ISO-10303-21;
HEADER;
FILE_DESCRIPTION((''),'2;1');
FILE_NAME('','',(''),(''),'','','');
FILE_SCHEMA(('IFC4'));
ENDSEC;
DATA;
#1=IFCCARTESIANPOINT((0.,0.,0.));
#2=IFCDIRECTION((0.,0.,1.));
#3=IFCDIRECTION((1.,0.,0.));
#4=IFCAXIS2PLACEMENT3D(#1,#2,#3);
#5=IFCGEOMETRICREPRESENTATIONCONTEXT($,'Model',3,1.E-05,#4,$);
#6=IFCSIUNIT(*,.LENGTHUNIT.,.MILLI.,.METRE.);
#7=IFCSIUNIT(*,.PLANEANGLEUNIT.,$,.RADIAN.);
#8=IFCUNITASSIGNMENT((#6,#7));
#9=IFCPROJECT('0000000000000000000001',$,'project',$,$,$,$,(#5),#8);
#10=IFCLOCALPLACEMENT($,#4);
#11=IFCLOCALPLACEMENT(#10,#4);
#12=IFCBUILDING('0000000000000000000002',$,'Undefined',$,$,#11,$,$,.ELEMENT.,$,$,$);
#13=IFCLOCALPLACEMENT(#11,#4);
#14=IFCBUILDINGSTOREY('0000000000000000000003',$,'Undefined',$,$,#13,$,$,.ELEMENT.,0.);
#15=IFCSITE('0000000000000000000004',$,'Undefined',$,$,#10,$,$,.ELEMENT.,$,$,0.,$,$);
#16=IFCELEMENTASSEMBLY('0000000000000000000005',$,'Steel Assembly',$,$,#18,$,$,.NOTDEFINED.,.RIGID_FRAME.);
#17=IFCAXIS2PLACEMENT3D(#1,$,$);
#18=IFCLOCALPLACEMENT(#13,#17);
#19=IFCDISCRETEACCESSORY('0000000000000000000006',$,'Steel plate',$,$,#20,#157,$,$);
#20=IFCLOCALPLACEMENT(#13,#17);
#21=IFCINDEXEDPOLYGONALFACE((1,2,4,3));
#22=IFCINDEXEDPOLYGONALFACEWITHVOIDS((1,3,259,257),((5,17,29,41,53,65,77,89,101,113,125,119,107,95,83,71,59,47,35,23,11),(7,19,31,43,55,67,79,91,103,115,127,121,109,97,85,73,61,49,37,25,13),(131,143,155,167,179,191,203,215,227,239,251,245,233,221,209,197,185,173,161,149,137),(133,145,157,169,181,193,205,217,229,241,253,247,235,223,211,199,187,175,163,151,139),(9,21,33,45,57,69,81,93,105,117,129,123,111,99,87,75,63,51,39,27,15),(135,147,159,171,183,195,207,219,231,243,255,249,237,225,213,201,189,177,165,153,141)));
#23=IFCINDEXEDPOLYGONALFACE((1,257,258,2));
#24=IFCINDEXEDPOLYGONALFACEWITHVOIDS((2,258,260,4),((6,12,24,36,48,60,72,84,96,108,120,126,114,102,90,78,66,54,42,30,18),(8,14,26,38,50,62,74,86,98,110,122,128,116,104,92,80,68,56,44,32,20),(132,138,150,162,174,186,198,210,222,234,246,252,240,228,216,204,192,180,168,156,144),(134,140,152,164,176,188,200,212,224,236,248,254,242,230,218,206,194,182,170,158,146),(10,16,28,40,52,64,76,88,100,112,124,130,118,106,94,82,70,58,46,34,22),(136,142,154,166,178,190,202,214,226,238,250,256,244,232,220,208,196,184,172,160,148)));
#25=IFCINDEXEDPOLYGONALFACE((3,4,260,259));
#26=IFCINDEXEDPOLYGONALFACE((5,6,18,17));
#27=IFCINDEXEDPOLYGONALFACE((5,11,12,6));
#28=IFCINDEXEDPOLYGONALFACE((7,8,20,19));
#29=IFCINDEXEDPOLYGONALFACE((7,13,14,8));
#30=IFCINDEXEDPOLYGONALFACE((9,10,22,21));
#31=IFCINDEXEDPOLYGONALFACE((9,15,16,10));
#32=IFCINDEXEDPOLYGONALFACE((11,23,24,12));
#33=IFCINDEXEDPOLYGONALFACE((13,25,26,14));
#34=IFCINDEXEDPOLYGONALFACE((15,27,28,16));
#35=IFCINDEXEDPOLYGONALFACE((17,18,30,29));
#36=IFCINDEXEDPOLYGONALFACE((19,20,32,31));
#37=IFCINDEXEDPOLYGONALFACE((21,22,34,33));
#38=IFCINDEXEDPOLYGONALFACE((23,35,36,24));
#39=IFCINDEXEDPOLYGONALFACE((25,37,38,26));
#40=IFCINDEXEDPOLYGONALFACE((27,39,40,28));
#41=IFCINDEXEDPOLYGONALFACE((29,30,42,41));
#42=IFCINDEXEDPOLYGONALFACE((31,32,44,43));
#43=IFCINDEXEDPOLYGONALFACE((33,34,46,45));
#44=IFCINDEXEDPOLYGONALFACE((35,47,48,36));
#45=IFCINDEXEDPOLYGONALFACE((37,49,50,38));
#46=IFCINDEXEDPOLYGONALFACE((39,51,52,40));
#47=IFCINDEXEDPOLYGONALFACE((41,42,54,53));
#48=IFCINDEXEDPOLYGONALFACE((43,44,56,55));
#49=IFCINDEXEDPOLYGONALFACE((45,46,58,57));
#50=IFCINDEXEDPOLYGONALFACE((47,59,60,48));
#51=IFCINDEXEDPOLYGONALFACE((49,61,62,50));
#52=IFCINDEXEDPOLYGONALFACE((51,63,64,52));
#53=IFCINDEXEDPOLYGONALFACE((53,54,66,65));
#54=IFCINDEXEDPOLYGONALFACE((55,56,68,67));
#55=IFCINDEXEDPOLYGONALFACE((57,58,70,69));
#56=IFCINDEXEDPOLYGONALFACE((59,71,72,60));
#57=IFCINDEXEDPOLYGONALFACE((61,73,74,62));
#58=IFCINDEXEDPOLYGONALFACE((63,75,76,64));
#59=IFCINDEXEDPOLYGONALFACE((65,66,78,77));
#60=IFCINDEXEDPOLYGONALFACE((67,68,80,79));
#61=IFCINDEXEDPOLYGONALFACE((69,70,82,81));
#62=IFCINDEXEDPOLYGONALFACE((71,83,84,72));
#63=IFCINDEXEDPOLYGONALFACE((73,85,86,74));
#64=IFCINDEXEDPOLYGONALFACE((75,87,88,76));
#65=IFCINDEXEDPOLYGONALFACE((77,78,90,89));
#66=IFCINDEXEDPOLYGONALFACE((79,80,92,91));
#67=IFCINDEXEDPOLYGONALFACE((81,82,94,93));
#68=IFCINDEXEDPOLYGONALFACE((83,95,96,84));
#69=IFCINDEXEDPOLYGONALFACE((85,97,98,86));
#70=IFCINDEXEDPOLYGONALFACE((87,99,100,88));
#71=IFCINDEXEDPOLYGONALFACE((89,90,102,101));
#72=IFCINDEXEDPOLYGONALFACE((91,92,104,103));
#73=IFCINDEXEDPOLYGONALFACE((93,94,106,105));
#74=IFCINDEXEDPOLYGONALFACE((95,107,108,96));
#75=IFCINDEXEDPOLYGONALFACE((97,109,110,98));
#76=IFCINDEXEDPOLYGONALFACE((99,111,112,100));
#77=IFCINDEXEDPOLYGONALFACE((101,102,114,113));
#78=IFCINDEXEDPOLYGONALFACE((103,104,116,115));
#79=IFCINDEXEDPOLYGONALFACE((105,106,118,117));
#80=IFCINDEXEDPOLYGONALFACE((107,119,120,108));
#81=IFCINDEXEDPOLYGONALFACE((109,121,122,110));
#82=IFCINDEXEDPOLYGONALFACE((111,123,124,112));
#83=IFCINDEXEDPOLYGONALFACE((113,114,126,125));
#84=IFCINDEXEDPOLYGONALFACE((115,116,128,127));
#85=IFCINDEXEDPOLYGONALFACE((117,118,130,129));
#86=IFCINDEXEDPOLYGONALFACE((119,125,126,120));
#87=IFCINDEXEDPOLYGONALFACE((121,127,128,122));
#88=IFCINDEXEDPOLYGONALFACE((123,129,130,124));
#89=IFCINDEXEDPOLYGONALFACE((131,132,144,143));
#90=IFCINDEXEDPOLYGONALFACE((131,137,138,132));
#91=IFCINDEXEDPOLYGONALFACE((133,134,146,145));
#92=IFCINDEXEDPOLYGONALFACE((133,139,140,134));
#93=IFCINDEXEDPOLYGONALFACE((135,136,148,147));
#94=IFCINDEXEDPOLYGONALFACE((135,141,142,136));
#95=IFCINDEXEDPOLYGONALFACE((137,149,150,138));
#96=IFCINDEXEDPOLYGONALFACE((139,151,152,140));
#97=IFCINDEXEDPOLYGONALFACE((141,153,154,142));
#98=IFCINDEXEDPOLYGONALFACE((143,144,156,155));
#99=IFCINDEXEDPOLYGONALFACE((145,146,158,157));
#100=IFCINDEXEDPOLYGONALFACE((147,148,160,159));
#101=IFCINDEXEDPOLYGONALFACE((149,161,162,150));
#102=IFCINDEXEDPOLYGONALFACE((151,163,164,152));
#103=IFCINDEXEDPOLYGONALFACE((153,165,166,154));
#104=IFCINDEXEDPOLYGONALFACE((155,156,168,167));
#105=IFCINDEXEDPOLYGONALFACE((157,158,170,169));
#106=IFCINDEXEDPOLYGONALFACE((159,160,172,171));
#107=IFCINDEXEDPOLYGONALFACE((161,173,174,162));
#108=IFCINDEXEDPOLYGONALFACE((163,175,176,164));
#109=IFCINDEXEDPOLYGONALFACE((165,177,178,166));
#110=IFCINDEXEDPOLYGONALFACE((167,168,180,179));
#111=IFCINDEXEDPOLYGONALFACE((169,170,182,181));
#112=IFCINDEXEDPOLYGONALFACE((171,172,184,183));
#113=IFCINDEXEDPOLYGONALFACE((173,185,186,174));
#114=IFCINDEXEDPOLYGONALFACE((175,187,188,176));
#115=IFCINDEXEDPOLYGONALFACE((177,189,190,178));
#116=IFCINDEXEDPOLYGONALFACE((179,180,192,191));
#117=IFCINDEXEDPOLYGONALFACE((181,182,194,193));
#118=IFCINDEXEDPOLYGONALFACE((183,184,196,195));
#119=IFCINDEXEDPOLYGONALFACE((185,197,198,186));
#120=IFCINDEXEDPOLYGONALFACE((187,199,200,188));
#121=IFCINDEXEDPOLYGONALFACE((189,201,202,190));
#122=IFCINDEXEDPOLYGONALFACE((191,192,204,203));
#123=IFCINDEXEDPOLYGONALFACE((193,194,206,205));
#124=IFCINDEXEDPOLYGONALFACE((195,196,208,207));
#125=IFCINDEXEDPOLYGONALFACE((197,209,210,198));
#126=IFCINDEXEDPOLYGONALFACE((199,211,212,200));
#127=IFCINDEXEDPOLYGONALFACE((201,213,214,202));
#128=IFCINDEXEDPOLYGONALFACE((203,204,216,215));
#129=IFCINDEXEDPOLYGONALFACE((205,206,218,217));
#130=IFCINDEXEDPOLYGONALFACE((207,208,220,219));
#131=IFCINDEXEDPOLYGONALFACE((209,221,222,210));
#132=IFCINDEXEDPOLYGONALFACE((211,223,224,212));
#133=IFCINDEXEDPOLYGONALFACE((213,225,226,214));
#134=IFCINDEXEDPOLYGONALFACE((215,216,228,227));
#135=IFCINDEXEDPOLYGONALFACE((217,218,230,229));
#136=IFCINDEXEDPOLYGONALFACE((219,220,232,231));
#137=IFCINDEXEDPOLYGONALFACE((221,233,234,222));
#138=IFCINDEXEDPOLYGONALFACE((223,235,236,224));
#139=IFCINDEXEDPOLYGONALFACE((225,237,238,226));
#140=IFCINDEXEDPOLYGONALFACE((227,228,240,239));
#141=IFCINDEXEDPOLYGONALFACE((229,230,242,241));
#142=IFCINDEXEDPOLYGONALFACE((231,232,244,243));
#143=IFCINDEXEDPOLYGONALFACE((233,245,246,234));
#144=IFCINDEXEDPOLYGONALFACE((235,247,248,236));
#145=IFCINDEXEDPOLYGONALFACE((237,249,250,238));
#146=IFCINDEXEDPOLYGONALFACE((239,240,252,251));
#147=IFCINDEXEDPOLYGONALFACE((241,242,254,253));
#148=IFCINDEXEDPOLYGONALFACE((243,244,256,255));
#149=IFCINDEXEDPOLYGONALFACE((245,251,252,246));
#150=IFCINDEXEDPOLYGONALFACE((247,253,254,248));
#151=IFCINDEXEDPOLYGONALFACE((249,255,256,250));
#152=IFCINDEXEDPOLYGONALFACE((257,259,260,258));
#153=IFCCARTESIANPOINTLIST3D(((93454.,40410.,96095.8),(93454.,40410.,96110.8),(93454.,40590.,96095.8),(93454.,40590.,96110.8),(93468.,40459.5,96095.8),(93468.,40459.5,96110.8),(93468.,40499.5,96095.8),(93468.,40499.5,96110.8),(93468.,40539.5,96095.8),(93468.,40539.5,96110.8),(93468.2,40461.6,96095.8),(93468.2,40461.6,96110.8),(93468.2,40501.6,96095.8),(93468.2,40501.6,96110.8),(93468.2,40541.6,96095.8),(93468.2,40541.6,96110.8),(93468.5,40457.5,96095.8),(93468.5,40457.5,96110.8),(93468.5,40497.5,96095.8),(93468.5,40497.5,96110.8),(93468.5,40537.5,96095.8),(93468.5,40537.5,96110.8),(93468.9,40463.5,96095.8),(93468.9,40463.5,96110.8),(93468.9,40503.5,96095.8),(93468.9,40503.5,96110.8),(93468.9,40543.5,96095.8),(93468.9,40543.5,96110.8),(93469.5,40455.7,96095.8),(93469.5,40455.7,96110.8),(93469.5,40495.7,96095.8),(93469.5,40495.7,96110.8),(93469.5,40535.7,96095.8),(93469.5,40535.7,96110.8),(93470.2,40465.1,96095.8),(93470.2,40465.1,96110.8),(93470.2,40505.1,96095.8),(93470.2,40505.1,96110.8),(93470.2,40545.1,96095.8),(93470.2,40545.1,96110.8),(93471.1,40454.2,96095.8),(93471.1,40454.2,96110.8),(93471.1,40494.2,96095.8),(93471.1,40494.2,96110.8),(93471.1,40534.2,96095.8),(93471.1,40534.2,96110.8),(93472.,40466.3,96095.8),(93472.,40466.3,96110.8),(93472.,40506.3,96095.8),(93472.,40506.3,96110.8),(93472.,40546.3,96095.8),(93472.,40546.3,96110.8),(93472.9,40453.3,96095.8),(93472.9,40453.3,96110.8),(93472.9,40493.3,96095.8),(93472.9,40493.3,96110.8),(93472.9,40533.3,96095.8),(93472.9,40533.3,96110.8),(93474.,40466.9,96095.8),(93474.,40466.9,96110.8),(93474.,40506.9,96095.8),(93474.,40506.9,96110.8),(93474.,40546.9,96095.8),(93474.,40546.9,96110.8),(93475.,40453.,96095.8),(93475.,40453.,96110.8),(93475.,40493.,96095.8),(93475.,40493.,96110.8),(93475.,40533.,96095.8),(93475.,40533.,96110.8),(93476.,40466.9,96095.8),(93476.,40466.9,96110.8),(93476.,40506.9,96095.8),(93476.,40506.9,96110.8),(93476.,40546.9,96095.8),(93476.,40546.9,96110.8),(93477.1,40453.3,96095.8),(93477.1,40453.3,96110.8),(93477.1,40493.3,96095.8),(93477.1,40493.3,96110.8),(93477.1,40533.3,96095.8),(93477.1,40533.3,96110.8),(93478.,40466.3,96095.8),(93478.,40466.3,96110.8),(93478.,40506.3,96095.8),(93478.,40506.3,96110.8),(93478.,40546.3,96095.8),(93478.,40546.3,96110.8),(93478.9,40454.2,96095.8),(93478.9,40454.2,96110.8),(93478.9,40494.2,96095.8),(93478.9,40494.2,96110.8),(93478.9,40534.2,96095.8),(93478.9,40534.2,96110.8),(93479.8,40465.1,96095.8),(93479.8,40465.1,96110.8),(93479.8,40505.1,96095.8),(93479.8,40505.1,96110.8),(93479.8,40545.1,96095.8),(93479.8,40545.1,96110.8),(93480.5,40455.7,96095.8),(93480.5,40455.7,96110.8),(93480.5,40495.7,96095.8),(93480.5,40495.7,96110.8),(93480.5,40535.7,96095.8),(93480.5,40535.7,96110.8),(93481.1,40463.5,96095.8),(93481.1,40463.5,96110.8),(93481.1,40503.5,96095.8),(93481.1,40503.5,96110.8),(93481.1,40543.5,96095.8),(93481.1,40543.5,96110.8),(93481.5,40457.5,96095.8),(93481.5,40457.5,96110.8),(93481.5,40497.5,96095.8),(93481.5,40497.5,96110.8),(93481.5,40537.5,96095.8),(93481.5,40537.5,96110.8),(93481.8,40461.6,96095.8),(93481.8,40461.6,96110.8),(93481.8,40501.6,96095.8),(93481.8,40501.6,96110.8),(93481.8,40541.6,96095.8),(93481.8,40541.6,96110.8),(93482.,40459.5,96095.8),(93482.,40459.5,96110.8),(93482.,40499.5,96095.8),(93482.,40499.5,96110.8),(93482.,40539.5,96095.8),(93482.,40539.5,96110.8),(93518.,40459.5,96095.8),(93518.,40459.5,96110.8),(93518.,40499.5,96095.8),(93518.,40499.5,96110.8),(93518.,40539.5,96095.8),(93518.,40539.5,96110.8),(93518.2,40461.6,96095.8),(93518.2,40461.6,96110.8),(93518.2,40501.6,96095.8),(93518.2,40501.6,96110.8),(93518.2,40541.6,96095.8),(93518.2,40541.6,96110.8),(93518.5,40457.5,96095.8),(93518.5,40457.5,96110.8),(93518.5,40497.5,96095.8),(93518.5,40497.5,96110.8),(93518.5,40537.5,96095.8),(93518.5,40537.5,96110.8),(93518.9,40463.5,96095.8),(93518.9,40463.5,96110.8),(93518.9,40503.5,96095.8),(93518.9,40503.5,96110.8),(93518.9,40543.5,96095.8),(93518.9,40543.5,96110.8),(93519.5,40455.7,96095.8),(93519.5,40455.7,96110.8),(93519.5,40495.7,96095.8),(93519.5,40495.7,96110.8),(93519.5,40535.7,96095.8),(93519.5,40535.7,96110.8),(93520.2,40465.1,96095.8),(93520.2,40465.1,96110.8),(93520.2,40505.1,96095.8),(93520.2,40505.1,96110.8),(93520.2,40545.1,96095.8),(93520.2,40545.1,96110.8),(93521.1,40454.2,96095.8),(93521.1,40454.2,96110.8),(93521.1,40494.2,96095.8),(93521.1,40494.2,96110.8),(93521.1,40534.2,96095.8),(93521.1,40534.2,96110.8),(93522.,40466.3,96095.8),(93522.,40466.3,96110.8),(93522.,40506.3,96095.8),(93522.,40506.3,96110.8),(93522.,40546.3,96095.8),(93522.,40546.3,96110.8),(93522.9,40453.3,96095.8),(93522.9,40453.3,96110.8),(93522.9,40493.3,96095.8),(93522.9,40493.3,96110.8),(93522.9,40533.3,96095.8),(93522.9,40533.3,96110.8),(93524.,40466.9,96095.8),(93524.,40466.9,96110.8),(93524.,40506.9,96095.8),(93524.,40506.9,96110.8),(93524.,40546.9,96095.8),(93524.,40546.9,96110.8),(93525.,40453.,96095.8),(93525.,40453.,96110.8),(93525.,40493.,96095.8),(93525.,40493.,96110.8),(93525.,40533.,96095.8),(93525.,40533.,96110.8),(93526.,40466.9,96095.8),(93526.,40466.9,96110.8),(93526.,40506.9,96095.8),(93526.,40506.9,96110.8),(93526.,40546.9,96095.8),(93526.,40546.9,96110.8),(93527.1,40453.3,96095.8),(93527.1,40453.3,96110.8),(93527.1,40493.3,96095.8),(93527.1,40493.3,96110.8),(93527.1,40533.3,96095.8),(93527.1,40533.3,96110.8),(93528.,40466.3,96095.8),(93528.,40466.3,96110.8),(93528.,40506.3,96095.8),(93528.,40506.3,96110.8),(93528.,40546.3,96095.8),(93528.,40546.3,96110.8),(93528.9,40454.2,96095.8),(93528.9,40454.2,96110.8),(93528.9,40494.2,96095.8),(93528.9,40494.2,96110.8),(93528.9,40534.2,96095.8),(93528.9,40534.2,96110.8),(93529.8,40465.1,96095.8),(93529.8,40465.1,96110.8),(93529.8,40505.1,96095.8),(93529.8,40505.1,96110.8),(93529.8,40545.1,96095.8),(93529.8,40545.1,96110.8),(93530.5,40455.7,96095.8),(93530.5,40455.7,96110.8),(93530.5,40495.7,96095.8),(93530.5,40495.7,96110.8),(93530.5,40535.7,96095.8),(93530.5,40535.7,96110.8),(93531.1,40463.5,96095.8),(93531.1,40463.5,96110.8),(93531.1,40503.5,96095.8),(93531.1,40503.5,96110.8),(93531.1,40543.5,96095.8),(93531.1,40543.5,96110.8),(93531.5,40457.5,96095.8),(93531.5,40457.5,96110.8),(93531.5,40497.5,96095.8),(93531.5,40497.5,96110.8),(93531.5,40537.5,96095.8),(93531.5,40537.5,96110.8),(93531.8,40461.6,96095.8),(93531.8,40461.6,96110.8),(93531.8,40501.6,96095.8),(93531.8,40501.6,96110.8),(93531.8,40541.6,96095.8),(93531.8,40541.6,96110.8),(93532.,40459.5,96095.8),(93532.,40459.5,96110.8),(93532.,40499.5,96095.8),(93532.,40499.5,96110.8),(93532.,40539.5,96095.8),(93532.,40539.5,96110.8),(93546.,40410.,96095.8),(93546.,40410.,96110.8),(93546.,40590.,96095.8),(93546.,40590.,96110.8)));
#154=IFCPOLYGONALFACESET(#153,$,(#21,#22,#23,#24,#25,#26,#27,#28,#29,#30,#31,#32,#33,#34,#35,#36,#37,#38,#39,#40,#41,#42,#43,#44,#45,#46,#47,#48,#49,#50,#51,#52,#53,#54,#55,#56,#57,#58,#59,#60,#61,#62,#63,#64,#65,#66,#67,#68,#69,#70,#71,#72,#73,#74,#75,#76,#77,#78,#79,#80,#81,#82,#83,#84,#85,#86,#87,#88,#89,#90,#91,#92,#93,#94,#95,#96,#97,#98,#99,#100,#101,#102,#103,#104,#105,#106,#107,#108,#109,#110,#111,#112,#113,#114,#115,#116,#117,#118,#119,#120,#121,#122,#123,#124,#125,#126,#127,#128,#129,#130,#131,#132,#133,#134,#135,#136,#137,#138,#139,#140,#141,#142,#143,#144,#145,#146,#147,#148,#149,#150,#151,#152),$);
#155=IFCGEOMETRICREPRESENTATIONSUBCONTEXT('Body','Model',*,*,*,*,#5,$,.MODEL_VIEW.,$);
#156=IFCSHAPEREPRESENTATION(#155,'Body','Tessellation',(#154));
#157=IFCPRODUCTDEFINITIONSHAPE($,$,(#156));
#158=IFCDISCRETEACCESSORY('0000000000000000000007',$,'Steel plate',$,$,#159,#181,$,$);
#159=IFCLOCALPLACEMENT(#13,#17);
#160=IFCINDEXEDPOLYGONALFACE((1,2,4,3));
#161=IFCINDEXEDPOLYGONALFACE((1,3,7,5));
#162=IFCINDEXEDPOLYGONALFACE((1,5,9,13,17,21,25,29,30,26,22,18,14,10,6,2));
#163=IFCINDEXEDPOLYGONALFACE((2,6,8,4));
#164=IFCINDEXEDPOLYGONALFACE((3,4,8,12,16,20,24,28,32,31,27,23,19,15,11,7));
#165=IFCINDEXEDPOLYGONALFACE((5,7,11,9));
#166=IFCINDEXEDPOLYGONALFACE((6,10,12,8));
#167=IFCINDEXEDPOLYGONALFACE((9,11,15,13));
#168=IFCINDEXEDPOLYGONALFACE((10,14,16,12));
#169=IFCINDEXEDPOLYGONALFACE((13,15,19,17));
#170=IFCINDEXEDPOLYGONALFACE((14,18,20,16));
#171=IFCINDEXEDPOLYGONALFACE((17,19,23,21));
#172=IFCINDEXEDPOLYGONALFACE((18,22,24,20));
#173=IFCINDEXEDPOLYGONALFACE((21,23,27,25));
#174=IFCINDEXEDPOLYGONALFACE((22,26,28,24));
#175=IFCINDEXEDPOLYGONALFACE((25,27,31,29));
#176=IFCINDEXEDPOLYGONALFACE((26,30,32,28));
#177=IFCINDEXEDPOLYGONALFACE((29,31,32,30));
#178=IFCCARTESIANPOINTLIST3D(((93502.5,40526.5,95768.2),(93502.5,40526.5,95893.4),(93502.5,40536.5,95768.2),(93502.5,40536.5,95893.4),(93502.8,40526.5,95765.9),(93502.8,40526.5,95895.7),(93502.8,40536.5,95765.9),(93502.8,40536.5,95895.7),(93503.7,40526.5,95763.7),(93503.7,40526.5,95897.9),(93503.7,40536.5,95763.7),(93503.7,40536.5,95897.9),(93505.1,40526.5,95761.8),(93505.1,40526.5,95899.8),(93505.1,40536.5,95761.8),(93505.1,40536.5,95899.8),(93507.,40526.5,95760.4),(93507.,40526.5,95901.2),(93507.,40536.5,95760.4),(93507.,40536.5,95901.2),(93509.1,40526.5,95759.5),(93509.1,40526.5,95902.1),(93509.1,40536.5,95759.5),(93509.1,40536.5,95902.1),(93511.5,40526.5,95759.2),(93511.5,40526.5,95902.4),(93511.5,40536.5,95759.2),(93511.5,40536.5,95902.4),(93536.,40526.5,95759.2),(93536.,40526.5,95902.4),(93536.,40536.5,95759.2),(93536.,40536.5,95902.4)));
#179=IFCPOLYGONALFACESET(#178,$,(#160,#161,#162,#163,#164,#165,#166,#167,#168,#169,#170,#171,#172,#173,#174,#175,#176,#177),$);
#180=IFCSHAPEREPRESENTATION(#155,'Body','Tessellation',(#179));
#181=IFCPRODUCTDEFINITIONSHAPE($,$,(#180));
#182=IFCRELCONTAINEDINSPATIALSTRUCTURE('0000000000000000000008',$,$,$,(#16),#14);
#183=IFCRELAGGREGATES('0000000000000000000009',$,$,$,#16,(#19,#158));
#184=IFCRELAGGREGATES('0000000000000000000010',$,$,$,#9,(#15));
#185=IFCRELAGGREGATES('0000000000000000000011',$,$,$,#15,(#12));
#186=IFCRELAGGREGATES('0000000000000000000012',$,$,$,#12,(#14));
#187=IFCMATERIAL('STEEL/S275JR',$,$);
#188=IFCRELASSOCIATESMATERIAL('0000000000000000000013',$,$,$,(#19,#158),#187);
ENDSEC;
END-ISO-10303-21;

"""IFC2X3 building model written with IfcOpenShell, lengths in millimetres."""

from ifc_helpers import new_model, si_unit, frame, frame_2d, origin_with_axes, origin_2d_with_axis, place, context, subcontext, project, spatial, polyline, circle_curve, parameter, trimmed, segment, composite_curve, circle, outline, extrude, source, transform, mapped, material, element, aggregate, save


model = new_model("IFC2X3")

# Units and contexts
model_context = context("Model", 3, precision=1e-05, world=origin_with_axes())
body_context = subcontext(model_context, "Body", "Model", "MODEL_VIEW")
ifc_project = project(units=[si_unit("LENGTHUNIT", "METRE", prefix="MILLI"), si_unit("PLANEANGLEUNIT", "RADIAN")], contexts=[model_context])

# Site, building, storey
site_placement = place(None, origin_with_axes())
site = spatial("IfcSite", under=ifc_project, at=site_placement, Name="Undefined", CompositionType="ELEMENT", RefElevation=0.0)
building_placement = place(site_placement, origin_with_axes())
building = spatial("IfcBuilding", under=site, at=building_placement, Name="Undefined", CompositionType="ELEMENT")
storey_placement = place(building_placement, origin_with_axes())
storey = spatial("IfcBuildingStorey", under=building, at=storey_placement, Name="Undefined", CompositionType="ELEMENT", Elevation=0.0)

# Shared definitions
ifc_material_1 = material(Name="STEEL/S275JR")

# Element assembly
assembly_1_placement = place(storey_placement, origin_with_axes())
assembly_1 = element("IfcElementAssembly", 1, at=assembly_1_placement, inside=storey, Name="Steel Assembly", AssemblyPlace="NOTDEFINED", PredefinedType="RIGID_FRAME")

# Discrete accessory, opening
discrete_accessory_1_placement = place(assembly_1_placement, frame((93546.0, 40410.0, 96103.3), z_axis=(0.0, 0.0, 1.0), x_axis=(0.0, 1.0, 0.0)))
discrete_accessory_1 = element("IfcDiscreteAccessory", 2, at=discrete_accessory_1_placement, material=ifc_material_1, Name="Steel plate", context=body_context, shape_type="SweptSolid", body=[
    extrude(outline(polyline([(0.0, 0.0), (180.0, 0.0), (180.0, 92.0), (0.0, 92.0), (0.0, 0.0)])), frame((0.0, 0.0, -7.5), z_axis=(0.0, 0.0, 1.0), x_axis=(1.0, 0.0, 0.0)), (0.0, 0.0, 1.0), 15.0),
])
shared_shape_1 = source(origin_with_axes(), body_context, "Body", "SweptSolid", [
    extrude(circle(Radius=7.0, at=origin_2d_with_axis()), frame((0.0, 15.9, 0.0), z_axis=(0.0, 1.0, 0.0), x_axis=(1.0, 0.0, 0.0)), (0.0, 0.0, 1.0), 31.1),
])
opening_1_placement = place(assembly_1_placement, frame((93500.0, 40540.0, 96126.8), z_axis=(1.0, 0.0, 0.0), x_axis=(0.0, -1.0, 0.0)))
element("IfcOpeningElement", 3, at=opening_1_placement, cuts=discrete_accessory_1, ObjectType="Opening", context=body_context, shape_type="MappedRepresentation", body=[
    mapped(shared_shape_1, transform((0.0, 0.0, -25.0))),
    mapped(shared_shape_1, transform((40.0, 0.0, -25.0))),
    mapped(shared_shape_1, transform((80.0, 0.0, -25.0))),
    mapped(shared_shape_1, transform((0.0, 0.0, 25.0))),
    mapped(shared_shape_1, transform((40.0, 0.0, 25.0))),
    mapped(shared_shape_1, transform((80.0, 0.0, 25.0))),
])

# Discrete accessory
discrete_accessory_2_placement = place(assembly_1_placement, frame((93502.5, 40531.5, 95902.4), z_axis=(0.0, 1.0, 0.0), x_axis=(1.0, 0.0, 0.0)))
discrete_accessory_2 = element("IfcDiscreteAccessory", 4, at=discrete_accessory_2_placement, material=ifc_material_1, Name="Steel plate", context=body_context, shape_type="SweptSolid", body=[
    extrude(outline(composite_curve([segment(trimmed(circle_curve(frame_2d((9.0, 9.0), x_axis=(-1.0, 0.0)), 9.0), [parameter(0.0)], [parameter(1.570796)], True, "PARAMETER"), True, "CONTINUOUS"), segment(polyline([(9.0, 0.0), (33.5, 0.0), (33.5, 143.2), (9.0, 143.2)]), True, "CONTINUOUS"), segment(trimmed(circle_curve(frame_2d((9.0, 134.2), x_axis=(0.0, 1.0)), 9.0), [parameter(0.0)], [parameter(1.570796)], True, "PARAMETER"), True, "CONTINUOUS"), segment(polyline([(0.0, 134.2), (0.0, 9.0)]), True, "DISCONTINUOUS")], self_intersect=False)), frame((0.0, 0.0, -5.0), z_axis=(0.0, 0.0, 1.0), x_axis=(1.0, 0.0, 0.0)), (0.0, 0.0, 1.0), 10.0),
])

aggregate(assembly_1, [discrete_accessory_1, discrete_accessory_2])

save(model, "model.ifc")
